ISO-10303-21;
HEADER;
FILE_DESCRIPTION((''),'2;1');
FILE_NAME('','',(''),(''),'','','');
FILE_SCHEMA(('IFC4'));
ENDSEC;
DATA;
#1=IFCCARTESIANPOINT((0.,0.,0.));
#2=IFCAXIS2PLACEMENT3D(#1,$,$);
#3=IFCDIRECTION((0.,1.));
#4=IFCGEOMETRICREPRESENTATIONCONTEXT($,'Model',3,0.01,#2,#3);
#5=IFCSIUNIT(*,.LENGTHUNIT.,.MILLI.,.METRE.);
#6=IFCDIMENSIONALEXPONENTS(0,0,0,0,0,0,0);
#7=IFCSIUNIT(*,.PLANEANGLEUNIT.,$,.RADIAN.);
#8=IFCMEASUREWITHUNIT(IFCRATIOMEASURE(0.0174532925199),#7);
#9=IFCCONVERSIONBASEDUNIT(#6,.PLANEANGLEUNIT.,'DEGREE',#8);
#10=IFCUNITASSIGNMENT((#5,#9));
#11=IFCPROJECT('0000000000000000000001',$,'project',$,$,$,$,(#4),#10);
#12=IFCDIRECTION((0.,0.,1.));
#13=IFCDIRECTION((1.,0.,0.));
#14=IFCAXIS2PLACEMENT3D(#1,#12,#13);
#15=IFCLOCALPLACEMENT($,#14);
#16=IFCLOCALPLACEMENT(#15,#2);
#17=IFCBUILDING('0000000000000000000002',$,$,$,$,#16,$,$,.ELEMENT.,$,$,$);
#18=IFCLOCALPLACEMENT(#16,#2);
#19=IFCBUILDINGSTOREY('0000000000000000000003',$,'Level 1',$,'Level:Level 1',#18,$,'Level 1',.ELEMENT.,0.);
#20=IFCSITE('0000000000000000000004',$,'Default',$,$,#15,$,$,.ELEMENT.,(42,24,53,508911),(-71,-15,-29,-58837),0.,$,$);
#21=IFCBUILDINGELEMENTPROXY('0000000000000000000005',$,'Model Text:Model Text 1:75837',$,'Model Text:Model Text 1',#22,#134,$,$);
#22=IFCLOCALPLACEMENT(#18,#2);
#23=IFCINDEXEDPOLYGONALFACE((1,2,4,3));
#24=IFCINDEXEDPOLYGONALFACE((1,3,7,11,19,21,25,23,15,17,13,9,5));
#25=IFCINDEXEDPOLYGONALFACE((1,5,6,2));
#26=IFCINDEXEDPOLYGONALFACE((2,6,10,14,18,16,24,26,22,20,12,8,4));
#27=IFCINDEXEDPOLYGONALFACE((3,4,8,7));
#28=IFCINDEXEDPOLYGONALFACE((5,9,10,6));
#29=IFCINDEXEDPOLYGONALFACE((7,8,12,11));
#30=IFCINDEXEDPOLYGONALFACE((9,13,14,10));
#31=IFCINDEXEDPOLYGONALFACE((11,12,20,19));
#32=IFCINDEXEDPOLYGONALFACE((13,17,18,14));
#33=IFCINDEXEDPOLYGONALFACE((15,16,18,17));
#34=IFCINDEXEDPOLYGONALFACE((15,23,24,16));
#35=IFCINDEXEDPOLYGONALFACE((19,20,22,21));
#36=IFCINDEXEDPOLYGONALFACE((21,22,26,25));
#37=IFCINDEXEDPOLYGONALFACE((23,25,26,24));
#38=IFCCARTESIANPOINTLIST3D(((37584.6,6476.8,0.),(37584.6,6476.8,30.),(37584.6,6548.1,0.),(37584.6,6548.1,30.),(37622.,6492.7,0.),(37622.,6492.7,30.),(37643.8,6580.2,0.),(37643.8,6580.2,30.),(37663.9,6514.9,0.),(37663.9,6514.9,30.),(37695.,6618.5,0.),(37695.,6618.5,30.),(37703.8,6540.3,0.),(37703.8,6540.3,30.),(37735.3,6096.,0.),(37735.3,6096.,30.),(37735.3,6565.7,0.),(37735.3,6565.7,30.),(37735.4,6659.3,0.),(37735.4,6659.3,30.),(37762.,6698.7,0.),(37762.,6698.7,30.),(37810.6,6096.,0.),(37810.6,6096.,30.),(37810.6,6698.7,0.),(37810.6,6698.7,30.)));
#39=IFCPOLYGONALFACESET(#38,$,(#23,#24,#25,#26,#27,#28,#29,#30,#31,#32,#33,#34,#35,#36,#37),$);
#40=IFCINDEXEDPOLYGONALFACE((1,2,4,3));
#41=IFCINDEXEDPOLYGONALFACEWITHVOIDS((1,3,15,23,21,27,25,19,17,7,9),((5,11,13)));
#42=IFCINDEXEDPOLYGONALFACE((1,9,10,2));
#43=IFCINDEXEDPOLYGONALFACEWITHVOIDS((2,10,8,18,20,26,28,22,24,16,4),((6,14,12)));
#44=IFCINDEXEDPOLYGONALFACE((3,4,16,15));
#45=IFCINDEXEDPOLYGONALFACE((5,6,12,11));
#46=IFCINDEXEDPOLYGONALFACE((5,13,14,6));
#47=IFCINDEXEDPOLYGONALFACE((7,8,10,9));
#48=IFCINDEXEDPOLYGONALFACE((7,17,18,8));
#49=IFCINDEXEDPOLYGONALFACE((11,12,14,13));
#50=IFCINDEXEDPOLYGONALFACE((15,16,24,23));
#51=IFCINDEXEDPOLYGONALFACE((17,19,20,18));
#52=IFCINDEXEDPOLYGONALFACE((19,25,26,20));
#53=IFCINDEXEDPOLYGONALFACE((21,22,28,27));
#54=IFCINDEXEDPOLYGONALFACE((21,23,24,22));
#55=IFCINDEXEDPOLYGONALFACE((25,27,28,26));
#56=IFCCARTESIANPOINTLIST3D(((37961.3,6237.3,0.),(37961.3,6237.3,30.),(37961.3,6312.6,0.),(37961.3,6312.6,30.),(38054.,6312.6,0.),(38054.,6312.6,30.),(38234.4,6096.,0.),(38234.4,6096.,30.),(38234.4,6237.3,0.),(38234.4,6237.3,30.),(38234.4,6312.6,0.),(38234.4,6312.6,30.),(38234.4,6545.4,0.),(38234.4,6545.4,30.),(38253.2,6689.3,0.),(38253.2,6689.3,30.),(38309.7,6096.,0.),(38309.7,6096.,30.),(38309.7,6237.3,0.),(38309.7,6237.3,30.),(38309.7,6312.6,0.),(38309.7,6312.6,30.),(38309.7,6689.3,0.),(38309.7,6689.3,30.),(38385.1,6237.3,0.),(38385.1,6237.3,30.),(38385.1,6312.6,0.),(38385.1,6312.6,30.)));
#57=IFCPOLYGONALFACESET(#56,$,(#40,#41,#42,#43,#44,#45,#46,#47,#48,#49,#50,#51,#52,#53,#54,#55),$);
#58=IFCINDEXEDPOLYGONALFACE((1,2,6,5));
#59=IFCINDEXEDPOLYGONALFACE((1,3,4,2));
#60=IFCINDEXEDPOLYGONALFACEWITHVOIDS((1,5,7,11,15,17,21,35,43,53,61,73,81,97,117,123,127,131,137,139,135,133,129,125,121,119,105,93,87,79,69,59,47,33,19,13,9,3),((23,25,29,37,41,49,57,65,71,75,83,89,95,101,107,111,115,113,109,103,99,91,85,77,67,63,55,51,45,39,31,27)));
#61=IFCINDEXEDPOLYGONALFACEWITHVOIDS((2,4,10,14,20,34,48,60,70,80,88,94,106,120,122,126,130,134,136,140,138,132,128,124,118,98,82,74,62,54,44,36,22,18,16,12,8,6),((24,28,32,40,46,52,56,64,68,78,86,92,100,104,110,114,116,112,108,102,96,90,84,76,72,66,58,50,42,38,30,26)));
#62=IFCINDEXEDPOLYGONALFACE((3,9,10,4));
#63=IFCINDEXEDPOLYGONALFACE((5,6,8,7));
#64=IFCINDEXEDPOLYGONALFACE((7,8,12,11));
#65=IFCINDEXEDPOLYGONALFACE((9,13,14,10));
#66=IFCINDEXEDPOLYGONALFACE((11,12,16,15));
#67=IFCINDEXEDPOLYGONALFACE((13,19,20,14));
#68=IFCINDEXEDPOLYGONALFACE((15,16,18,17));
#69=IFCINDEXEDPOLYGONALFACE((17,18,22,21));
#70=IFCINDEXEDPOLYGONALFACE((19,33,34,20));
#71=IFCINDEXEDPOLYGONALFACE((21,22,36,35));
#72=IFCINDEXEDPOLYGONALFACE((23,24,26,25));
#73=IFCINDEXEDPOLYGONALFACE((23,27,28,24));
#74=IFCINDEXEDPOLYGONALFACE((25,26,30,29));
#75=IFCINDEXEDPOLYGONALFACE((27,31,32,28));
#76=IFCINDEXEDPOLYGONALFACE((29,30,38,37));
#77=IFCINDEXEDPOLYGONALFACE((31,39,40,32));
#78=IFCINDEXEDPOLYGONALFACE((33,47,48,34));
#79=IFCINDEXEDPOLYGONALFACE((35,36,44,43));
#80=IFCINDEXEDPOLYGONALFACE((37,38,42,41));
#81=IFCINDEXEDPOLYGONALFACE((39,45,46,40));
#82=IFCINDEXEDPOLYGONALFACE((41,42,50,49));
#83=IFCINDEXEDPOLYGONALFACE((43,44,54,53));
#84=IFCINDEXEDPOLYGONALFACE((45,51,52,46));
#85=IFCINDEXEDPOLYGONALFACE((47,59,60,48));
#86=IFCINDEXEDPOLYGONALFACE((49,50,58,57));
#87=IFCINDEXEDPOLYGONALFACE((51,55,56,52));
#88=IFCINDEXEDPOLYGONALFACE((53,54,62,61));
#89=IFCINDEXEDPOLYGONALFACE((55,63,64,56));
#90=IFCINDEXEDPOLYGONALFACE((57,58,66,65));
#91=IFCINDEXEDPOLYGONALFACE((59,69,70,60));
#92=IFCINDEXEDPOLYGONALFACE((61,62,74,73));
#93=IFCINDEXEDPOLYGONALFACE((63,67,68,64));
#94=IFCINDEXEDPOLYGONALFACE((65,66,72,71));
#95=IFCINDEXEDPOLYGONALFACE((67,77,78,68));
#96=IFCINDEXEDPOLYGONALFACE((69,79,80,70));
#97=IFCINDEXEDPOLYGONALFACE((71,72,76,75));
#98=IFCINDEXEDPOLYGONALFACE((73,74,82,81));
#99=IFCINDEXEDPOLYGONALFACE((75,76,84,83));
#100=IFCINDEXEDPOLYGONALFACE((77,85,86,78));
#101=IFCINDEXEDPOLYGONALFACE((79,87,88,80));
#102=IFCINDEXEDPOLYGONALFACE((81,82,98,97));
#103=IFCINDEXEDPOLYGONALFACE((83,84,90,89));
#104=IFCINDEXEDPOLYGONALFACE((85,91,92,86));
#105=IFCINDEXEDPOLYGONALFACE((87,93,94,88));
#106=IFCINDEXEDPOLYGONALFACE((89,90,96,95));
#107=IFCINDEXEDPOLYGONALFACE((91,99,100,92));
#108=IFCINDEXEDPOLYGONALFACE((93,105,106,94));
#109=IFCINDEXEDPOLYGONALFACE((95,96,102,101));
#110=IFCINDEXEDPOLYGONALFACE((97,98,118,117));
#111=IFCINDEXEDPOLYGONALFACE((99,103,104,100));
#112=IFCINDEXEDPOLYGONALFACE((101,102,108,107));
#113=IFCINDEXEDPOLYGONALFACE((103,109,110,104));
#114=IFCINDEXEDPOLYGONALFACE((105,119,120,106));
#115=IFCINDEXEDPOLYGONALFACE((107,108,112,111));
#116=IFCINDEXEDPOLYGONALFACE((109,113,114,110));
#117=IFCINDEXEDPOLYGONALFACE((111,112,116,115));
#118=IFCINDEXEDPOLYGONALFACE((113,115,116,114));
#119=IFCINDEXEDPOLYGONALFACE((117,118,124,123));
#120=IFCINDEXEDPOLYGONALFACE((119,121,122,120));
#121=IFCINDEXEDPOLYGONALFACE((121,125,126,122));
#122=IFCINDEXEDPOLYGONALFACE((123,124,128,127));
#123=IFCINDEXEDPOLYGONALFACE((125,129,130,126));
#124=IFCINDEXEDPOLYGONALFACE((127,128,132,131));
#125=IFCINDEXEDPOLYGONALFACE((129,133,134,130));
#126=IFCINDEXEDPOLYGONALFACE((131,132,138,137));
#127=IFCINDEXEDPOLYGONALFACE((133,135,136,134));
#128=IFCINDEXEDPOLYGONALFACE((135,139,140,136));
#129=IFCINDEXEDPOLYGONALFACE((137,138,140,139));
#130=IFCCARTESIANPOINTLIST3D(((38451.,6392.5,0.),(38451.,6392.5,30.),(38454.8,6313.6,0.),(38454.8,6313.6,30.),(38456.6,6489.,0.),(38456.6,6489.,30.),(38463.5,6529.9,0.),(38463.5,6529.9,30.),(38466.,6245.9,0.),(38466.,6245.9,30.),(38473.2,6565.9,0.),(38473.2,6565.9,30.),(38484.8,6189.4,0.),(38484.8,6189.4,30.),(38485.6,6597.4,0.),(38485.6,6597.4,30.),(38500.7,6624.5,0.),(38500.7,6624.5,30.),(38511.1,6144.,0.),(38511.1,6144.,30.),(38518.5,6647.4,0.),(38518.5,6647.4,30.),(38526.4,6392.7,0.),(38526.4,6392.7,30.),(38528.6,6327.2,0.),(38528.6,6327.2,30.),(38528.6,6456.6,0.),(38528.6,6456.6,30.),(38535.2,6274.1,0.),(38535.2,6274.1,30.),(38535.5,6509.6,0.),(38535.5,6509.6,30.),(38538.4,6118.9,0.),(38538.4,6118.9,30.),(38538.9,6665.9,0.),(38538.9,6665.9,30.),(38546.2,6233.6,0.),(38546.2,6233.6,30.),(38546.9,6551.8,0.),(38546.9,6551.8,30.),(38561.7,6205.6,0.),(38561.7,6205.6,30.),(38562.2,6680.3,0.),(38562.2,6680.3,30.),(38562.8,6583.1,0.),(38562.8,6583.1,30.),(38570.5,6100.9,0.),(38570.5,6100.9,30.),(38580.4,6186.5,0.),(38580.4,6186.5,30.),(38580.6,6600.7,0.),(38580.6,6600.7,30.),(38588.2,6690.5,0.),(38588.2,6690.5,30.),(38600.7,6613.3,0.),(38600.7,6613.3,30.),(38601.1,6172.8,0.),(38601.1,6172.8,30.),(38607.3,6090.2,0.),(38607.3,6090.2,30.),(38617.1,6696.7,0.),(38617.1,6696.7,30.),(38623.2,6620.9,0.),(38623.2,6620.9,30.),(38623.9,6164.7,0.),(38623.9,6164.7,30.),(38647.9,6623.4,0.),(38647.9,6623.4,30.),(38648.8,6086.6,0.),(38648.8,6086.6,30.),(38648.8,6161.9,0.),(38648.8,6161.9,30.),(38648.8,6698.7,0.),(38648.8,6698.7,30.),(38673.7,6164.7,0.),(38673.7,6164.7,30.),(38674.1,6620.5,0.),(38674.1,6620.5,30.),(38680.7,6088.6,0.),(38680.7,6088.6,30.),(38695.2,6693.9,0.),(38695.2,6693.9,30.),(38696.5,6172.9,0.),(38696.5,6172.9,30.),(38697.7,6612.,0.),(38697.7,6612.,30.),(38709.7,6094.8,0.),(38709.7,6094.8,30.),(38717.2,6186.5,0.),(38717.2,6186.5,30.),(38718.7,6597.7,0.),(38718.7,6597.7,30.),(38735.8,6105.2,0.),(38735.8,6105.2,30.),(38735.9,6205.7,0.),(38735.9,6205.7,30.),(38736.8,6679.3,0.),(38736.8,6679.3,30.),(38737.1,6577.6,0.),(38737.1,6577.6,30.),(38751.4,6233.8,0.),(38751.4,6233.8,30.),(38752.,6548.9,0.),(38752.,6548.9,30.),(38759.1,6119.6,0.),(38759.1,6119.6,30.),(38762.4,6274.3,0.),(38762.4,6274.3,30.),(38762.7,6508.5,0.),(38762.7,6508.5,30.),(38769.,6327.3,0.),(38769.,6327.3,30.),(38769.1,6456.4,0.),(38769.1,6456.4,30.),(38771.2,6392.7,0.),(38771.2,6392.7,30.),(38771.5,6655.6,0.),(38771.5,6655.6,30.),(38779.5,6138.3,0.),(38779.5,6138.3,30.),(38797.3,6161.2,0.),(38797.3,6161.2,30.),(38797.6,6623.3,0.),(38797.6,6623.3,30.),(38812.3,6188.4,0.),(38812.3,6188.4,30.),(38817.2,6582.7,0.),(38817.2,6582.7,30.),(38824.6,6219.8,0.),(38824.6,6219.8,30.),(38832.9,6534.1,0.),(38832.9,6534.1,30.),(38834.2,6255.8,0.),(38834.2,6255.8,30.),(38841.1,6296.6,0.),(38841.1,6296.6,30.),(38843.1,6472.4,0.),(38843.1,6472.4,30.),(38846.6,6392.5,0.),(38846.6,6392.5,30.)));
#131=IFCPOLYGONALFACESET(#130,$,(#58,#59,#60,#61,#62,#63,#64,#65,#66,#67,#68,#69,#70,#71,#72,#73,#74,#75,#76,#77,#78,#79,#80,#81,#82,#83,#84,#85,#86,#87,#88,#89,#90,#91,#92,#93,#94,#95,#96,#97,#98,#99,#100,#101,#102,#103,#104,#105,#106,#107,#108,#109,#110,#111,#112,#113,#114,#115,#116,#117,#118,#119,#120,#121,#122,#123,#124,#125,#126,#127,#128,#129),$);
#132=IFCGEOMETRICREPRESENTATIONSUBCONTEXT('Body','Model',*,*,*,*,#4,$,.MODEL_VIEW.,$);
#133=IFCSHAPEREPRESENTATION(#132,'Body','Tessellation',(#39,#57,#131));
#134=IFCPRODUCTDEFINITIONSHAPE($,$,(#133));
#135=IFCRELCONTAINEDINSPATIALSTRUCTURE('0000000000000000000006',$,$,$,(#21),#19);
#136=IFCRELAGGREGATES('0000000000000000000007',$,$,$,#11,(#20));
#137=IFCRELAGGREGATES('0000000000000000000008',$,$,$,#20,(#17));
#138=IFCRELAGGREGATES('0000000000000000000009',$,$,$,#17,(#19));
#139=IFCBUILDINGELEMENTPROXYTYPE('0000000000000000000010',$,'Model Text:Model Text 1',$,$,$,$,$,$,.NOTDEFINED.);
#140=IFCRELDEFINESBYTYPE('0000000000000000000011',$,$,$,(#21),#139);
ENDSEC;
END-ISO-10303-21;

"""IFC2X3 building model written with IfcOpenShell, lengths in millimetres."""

from ifc_helpers import new_model, entity, si_unit, converted_unit, direction, frame, origin, origin_with_axes, place, context, subcontext, project, spatial, polyline, outline, extrude, type_object, element, save


model = new_model("IFC2X3")

# Units and contexts
model_context = context("Model", 3, precision=0.01, world=origin(), true_north=direction((0.0, 1.0)))
body_context = subcontext(model_context, "Body", "Model", "MODEL_VIEW")
ifc_project = project(units=[si_unit("LENGTHUNIT", "METRE", prefix="MILLI"), converted_unit("PLANEANGLEUNIT", "DEGREE", entity("IfcRatioMeasure", 0.0174532925199), si_unit("PLANEANGLEUNIT", "RADIAN"), dimensions=[0, 0, 0, 0, 0, 0, 0])], contexts=[model_context])

# Site, building, storey
site_placement = place(None, origin_with_axes())
site = spatial("IfcSite", under=ifc_project, at=site_placement, Name="Default", CompositionType="ELEMENT", RefLatitude=(42, 24, 53, 508911), RefLongitude=(-71, -15, -29, -58837), RefElevation=0.0)
building_placement = place(site_placement, origin())
building = spatial("IfcBuilding", under=site, at=building_placement, CompositionType="ELEMENT")
storey_placement = place(building_placement, origin())
storey = spatial("IfcBuildingStorey", under=building, at=storey_placement, Name="Level 1", ObjectType="Level:Level 1", LongName="Level 1", CompositionType="ELEMENT", Elevation=0.0)

# Building element proxy
building_element_proxy_type_1 = type_object("IfcBuildingElementProxyType", Name="Model Text:Model Text 1", PredefinedType="NOTDEFINED")
proxy_1_placement = place(storey_placement, frame((37584.6, 6086.6, 0.0)))
element("IfcBuildingElementProxy", 1, at=proxy_1_placement, inside=storey, type_object=building_element_proxy_type_1, Name="Model Text:Model Text 1:75837", ObjectType="Model Text:Model Text 1", context=body_context, shape_type="SweptSolid", body=[
    extrude(outline(polyline([(-410.6, -111.6), (192.1, -111.6), (192.1, -63.1), (152.7, -36.4), (111.9, 4.0), (73.6, 55.2), (41.4, 114.4), (-29.8, 114.4), (-13.9, 77.0), (8.3, 35.1), (33.7, -4.8), (59.1, -36.3), (-410.6, -36.3), (-410.6, -111.6)])), frame((114.4, 420.0, 0.0), z_axis=(0.0, 0.0, 1.0), x_axis=(0.0, 1.0, 0.0)), (0.0, 0.0, 1.0), 30.0),
    extrude(outline(polyline([(-6.8, -218.3), (68.5, -218.3), (68.5, -77.1), (143.8, -77.1), (143.8, -1.7), (68.5, -1.7), (68.5, 375.0), (12.0, 375.0), (-280.0, -1.7), (-280.0, -77.1), (-6.8, -77.1), (-6.8, -218.3)]), holes=[polyline([(-6.8, -1.7), (-187.3, -1.7), (-6.8, 231.1), (-6.8, -1.7)])]), frame((656.7, 227.7, 0.0)), (0.0, 0.0, 1.0), 30.0),
    extrude(outline(polyline([(-10.6, -198.7), (68.3, -198.7), (136.5, -190.7), (193.9, -174.7), (240.5, -150.6), (266.9, -124.4), (286.3, -93.2), (298.8, -57.0), (304.3, -15.7), (303.8, 16.2), (299.0, 45.5), (289.9, 72.1), (276.6, 96.0), (258.9, 117.3), (236.9, 136.2), (210.4, 152.5), (179.6, 166.3), (144.1, 177.6), (103.7, 186.3), (8.2, 196.4), (-71.8, 196.7), (-134.0, 189.4), (-183.3, 176.1), (-224.7, 158.4), (-258.2, 133.9), (-283.5, 100.3), (-300.1, 59.5), (-307.1, 13.4), (-306.6, -18.4), (-301.8, -47.5), (-292.8, -74.0), (-279.6, -97.9), (-262.0, -119.2), (-240.0, -138.1), (-213.6, -154.5), (-182.8, -168.4), (-147.3, -179.8), (-106.7, -188.6), (-10.6, -198.7)]), holes=[polyline([(-7.2, -123.5), (-71.0, -118.2), (-123.6, -108.8), (-165.2, -95.4), (-195.7, -78.0), (-212.4, -59.4), (-224.1, -38.7), (-230.6, -15.9), (-231.9, 8.9), (-227.8, 35.0), (-218.1, 58.1), (-202.8, 78.4), (-182.0, 95.8), (-152.6, 109.4), (-111.7, 118.1), (-59.4, 122.0), (4.4, 121.1), (69.6, 115.8), (122.2, 106.7), (162.2, 93.7), (189.5, 77.0), (207.7, 57.4), (220.4, 36.0), (227.5, 12.8), (229.1, -12.1), (225.2, -36.8), (215.9, -59.2), (201.3, -79.3), (181.4, -97.1), (152.6, -111.2), (111.6, -120.3), (58.3, -124.4), (-7.2, -123.5)])]), frame((1065.4, 304.7, 0.0), z_axis=(0.0, 0.0, 1.0), x_axis=(0.047515, -0.998871, 0.0)), (0.0, 0.0, 1.0), 30.0),
])

save(model, "model.ifc")
